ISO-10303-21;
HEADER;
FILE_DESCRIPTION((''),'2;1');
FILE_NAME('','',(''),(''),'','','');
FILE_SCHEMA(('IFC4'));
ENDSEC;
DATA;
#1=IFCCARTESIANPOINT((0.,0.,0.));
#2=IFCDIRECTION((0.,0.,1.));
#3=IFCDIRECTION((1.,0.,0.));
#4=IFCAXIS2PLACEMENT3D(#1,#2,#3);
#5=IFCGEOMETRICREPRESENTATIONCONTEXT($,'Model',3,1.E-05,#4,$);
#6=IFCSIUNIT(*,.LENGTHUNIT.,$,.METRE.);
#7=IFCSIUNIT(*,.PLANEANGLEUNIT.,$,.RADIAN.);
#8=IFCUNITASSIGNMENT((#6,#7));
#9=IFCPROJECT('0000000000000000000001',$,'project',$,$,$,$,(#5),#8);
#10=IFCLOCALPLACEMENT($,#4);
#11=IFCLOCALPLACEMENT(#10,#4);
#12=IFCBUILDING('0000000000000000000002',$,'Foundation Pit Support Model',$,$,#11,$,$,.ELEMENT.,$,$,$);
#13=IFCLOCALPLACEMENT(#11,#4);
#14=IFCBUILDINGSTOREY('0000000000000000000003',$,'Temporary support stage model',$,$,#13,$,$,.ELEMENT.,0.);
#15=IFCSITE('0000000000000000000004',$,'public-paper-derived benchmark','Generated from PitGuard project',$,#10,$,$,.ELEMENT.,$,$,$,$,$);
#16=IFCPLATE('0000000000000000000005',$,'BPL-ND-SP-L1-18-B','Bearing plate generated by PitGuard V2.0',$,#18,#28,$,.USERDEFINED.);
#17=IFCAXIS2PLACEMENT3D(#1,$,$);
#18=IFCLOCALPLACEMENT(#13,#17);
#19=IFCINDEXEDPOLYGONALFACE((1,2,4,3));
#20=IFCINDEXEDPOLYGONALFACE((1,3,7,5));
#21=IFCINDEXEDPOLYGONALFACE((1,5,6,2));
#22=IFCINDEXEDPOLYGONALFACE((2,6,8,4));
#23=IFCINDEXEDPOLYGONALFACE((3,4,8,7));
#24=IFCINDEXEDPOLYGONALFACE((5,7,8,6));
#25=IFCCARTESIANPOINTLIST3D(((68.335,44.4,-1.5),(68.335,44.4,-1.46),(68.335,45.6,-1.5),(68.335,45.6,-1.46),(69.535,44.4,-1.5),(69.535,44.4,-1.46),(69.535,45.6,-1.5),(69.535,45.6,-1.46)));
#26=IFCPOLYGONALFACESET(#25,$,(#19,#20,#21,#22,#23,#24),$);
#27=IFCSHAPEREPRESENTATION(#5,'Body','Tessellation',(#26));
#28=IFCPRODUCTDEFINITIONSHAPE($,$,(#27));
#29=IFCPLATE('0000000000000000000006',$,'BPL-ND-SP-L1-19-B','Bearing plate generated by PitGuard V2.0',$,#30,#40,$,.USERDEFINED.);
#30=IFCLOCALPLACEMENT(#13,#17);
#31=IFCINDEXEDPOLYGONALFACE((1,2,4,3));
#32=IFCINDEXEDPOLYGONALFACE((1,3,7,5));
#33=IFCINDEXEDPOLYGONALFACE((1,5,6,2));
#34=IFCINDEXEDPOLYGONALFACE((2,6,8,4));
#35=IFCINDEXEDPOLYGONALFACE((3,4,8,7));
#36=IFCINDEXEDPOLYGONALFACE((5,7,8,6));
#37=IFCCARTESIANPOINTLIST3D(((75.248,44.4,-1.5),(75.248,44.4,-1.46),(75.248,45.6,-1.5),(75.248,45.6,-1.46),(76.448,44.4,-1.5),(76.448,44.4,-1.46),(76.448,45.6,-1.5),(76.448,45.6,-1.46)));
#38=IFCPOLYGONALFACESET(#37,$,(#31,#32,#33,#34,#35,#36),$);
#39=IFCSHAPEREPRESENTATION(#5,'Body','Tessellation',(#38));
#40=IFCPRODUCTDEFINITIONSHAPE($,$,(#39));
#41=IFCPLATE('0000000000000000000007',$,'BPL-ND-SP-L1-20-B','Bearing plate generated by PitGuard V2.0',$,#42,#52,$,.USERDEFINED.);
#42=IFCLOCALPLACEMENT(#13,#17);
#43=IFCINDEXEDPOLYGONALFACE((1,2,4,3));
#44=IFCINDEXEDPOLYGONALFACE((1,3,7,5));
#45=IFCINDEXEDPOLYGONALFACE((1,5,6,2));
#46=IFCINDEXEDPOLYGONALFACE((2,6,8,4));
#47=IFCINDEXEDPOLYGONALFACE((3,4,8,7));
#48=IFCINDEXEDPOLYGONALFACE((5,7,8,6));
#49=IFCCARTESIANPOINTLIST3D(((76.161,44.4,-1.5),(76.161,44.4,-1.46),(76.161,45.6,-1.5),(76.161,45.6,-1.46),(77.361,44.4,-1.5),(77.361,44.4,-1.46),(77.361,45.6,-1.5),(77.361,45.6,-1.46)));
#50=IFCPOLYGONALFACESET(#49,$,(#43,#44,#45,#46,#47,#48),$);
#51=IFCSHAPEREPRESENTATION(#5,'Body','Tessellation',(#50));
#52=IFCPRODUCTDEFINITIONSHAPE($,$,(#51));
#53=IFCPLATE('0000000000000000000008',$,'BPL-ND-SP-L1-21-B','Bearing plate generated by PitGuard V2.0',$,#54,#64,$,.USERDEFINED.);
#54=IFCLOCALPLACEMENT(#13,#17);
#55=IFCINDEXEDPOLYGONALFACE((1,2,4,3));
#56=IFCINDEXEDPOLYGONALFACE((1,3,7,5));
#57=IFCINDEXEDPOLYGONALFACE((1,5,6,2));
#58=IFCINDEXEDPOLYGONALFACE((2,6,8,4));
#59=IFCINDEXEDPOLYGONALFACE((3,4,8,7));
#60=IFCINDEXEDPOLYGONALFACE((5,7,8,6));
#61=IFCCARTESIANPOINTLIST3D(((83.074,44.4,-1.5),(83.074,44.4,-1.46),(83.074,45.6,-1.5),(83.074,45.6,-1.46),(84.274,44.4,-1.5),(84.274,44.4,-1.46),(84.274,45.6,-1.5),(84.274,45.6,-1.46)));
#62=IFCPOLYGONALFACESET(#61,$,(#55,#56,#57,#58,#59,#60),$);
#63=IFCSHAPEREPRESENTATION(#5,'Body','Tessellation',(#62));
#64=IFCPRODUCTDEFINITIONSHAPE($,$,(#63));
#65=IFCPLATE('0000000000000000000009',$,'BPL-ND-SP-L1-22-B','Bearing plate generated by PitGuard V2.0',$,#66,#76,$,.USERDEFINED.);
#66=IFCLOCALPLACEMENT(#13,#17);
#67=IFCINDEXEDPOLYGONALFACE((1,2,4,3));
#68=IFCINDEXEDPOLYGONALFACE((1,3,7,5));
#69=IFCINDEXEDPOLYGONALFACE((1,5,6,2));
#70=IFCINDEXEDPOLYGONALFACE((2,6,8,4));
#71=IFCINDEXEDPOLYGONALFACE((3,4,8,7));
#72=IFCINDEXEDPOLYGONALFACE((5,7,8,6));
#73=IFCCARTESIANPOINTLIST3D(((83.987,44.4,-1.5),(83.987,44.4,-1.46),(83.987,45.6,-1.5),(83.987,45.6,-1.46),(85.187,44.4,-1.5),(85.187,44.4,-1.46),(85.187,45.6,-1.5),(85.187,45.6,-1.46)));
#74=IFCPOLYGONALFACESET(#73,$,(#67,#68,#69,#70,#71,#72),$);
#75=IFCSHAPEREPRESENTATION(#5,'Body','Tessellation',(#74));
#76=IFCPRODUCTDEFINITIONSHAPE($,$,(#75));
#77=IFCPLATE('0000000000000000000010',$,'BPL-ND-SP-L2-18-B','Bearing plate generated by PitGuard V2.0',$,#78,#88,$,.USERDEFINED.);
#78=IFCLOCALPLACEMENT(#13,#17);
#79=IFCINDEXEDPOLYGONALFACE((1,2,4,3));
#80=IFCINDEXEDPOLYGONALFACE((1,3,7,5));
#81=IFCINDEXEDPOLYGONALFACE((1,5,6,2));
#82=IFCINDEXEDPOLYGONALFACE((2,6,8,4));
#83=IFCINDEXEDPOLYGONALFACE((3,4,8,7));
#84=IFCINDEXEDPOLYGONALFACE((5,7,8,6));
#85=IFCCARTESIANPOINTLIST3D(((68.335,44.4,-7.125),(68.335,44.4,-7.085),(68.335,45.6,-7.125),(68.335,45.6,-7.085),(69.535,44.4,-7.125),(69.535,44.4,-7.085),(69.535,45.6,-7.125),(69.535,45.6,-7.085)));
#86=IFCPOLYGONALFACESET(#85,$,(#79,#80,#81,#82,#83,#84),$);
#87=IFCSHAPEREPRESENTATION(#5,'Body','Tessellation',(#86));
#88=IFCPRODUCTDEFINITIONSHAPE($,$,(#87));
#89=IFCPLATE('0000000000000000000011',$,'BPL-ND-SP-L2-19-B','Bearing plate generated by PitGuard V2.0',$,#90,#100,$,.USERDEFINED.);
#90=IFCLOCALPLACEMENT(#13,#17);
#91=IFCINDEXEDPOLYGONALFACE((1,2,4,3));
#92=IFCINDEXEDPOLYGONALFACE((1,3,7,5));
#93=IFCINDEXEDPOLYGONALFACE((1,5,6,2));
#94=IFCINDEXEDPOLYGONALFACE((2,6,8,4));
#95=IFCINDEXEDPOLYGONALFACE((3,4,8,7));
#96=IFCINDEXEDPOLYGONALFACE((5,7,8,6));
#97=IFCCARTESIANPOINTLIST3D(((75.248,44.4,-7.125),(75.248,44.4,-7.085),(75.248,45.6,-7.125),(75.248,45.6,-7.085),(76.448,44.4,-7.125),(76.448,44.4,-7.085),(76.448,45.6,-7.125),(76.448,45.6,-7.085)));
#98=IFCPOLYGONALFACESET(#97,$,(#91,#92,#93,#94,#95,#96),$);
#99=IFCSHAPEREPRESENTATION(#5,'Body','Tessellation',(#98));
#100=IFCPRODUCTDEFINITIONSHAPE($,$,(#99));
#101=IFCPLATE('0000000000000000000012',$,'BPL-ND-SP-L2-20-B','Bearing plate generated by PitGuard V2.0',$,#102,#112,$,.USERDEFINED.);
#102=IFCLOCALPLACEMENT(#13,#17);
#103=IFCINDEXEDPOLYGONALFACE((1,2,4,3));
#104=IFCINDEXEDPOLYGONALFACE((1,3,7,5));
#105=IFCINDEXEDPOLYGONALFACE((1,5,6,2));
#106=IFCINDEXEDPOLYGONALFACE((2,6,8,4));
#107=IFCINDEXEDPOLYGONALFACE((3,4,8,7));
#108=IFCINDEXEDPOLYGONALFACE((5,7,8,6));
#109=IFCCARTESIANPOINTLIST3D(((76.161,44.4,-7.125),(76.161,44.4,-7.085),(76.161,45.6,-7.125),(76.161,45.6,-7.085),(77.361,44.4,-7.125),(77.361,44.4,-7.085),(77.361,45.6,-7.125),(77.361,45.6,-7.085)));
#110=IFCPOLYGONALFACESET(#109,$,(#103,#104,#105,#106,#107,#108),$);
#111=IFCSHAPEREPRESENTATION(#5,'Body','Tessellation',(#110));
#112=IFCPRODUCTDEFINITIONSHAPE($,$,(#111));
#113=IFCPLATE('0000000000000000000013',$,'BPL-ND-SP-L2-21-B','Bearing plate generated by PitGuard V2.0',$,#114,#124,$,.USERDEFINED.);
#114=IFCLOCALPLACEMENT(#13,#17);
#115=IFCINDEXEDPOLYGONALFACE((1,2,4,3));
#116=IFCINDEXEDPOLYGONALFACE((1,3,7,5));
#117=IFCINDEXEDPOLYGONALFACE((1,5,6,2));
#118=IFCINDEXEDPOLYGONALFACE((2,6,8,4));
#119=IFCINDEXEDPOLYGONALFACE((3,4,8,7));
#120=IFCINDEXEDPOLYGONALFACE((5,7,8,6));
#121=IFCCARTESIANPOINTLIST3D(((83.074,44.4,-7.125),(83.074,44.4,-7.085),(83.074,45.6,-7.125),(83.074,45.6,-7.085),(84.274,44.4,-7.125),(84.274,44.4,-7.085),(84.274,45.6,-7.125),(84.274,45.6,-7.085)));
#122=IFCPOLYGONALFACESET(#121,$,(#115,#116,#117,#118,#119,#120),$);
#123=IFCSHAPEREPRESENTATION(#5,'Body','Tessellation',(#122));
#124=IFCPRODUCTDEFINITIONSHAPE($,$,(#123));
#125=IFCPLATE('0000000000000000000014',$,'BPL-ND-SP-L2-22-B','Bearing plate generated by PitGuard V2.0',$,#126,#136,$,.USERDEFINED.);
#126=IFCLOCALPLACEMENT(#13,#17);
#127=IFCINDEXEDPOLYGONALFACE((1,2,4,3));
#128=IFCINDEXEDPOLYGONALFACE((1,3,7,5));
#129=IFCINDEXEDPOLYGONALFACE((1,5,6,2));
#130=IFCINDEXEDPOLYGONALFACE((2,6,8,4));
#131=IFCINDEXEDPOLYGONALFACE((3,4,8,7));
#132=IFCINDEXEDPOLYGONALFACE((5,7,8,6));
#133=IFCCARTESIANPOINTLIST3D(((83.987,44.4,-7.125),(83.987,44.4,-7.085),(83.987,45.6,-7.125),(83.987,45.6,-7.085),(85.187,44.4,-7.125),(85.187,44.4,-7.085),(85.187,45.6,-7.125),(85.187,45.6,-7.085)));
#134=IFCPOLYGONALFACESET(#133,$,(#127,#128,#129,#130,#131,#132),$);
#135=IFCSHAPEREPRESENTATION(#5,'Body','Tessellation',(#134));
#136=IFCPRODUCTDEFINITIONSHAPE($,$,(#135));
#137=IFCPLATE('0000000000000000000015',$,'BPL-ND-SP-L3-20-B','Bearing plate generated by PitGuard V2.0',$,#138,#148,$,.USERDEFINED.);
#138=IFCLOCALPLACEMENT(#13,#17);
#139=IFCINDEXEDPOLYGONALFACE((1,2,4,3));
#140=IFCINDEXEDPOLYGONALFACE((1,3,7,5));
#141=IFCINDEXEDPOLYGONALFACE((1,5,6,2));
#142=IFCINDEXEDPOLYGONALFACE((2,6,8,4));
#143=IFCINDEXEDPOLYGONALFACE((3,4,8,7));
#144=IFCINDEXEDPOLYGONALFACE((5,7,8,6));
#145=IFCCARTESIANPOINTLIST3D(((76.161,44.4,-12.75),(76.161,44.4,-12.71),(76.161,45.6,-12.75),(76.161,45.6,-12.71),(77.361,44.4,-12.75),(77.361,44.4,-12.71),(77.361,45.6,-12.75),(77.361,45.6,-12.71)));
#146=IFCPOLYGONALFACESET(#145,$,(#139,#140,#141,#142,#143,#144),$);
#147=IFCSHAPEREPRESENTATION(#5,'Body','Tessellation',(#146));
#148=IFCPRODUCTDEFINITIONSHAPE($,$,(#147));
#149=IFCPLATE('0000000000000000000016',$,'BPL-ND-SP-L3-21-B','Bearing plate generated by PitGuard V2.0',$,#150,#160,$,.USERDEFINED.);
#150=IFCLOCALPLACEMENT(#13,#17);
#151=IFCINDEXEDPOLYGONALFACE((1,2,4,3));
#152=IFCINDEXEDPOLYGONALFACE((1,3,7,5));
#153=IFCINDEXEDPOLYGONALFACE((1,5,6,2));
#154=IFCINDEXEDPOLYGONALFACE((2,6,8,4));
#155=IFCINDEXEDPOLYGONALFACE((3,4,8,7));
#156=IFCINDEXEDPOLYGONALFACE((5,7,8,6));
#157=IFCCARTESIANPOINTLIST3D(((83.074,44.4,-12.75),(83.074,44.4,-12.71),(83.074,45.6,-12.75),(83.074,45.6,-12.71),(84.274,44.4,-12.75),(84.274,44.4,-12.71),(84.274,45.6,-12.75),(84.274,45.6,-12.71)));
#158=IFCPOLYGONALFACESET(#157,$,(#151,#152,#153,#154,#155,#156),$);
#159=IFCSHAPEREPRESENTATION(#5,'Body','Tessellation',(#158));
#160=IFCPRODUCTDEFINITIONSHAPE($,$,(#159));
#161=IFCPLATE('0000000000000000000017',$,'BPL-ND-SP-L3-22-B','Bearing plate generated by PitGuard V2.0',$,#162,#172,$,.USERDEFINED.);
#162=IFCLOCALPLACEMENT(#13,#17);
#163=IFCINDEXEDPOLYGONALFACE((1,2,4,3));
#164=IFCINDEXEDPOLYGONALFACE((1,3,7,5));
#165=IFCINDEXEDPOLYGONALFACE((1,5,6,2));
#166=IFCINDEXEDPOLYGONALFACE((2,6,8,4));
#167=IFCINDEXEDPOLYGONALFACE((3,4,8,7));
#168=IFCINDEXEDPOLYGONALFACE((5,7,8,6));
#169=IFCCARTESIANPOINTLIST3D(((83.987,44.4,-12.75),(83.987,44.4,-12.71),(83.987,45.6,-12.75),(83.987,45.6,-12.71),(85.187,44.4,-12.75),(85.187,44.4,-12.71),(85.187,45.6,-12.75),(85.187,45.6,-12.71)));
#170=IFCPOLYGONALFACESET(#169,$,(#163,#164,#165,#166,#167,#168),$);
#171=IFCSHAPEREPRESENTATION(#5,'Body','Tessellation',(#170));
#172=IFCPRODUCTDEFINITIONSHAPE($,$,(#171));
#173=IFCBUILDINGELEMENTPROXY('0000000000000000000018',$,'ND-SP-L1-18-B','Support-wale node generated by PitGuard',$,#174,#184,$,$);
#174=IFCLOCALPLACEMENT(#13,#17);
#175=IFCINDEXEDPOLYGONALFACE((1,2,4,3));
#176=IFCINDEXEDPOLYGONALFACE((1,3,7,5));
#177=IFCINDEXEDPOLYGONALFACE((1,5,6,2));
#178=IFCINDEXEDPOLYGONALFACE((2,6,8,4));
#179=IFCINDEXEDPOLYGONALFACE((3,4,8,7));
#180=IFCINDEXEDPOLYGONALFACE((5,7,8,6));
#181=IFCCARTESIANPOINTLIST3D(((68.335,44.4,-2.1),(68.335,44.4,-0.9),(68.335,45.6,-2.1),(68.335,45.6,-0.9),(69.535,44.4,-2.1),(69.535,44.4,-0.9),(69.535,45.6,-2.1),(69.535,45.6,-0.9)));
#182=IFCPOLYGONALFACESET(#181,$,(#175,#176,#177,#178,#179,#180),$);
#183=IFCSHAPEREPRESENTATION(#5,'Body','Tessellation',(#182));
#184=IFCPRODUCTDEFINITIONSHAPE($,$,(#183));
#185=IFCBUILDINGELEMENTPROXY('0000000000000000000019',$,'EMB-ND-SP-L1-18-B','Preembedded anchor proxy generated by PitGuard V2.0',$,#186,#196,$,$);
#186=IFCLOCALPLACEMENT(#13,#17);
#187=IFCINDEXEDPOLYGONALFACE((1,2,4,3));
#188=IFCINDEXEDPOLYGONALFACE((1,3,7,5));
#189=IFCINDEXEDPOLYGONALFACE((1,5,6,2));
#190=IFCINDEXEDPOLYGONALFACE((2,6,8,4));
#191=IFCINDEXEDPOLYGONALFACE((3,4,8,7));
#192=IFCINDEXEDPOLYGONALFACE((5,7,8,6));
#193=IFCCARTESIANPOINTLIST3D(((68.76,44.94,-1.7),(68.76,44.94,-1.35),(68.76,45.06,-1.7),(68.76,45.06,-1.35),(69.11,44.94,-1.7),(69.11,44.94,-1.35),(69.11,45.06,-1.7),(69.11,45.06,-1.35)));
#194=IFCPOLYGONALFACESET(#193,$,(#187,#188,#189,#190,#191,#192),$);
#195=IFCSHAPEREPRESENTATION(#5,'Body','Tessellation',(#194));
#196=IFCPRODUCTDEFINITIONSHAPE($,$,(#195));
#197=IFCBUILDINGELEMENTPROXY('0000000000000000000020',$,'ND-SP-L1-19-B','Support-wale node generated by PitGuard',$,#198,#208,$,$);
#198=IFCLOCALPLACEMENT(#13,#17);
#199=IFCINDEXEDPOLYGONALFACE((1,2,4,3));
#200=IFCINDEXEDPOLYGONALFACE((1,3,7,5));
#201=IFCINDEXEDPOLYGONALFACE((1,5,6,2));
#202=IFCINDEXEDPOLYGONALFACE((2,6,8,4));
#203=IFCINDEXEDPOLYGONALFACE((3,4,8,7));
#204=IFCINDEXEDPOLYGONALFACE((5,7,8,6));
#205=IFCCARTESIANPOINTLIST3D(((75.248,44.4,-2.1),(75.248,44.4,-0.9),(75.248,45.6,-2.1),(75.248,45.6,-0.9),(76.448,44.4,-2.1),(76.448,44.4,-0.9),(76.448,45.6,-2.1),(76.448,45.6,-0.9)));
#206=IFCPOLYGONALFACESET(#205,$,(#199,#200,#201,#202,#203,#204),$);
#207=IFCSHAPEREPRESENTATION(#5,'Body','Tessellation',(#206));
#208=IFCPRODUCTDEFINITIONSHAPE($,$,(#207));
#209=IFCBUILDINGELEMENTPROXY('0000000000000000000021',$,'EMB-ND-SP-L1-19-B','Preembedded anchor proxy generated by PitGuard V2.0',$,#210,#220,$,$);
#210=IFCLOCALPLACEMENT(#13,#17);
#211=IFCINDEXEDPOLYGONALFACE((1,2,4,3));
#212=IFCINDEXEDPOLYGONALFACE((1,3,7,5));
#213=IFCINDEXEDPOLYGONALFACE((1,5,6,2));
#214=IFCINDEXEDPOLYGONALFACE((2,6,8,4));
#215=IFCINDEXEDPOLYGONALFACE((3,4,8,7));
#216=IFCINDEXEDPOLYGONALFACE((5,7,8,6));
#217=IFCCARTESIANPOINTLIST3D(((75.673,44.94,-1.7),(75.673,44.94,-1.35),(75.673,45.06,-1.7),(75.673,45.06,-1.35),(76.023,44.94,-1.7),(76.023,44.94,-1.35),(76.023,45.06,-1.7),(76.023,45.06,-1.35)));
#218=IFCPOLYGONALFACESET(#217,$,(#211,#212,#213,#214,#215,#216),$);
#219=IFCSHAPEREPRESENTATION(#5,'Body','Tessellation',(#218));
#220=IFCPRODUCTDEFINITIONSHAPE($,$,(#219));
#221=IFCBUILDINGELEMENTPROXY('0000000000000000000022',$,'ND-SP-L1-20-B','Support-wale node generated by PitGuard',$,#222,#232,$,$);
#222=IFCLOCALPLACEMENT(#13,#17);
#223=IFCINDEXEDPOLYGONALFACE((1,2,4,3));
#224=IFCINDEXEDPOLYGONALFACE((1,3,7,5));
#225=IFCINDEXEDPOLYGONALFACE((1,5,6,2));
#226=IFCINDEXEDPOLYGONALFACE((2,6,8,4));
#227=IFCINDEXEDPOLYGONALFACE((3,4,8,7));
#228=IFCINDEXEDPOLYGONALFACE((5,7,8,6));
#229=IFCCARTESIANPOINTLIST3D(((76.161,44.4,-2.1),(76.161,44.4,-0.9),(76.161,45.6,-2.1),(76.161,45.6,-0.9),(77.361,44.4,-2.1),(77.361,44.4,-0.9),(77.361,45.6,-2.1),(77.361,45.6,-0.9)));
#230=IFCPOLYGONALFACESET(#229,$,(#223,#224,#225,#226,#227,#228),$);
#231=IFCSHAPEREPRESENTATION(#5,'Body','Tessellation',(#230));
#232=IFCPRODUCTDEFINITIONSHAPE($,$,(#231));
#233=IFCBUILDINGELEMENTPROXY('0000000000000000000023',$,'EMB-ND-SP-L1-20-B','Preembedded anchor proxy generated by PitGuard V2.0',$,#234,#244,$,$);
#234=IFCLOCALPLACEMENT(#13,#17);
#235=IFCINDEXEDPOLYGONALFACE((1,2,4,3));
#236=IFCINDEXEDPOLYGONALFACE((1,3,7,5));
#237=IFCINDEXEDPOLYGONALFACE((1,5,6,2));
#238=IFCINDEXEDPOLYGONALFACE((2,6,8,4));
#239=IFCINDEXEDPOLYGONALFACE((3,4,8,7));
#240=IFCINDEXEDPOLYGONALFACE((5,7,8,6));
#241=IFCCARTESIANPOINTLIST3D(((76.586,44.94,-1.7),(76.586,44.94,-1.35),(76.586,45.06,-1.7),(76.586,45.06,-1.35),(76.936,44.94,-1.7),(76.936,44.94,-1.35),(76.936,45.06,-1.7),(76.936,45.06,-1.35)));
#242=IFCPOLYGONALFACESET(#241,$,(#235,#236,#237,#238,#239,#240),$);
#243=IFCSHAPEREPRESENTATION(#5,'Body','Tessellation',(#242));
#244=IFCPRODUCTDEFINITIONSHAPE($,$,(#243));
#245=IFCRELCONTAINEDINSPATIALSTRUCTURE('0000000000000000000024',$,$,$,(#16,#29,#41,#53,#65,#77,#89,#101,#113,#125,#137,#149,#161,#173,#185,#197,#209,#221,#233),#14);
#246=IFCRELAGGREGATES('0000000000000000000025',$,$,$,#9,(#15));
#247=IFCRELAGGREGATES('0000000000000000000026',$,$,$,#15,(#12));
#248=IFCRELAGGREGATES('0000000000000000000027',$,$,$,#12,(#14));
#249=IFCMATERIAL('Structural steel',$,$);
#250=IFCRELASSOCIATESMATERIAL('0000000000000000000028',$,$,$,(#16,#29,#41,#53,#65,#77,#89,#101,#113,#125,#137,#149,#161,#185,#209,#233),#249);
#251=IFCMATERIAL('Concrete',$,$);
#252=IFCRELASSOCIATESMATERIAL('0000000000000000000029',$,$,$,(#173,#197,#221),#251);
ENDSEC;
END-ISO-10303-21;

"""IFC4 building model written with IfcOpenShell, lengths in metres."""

from ifc_helpers import new_model, si_unit, frame, origin_with_axes, origin_2d, place, context, project, spatial, rectangle, extrude, material, element, save


model = new_model("IFC4")

# Units and contexts
model_context = context("Model", 3, precision=1e-05, world=origin_with_axes())
ifc_project = project(units=[si_unit("LENGTHUNIT", "METRE"), si_unit("PLANEANGLEUNIT", "RADIAN")], contexts=[model_context])

# Site, building, storey
site_placement = place(None, origin_with_axes())
site = spatial("IfcSite", under=ifc_project, at=site_placement, Name="public-paper-derived benchmark", Description="Generated from PitGuard project", CompositionType="ELEMENT")
building_placement = place(site_placement, origin_with_axes())
building = spatial("IfcBuilding", under=site, at=building_placement, Name="Foundation Pit Support Model", CompositionType="ELEMENT")
storey_placement = place(building_placement, origin_with_axes())
storey = spatial("IfcBuildingStorey", under=building, at=storey_placement, Name="Temporary support stage model", CompositionType="ELEMENT", Elevation=0.0)

# Plates
ifc_material_1 = material(Name="Structural steel")
for number, where, z_axis, x_axis, name in (
    (1, (68.935, 45.0, -1.5), (0.0, 0.0, 1.0), (1.0, 0.0, 0.0), "BPL-ND-SP-L1-18-B"),
    (2, (75.848, 45.0, -1.5), (0.0, 0.0, 1.0), (1.0, 0.0, 0.0), "BPL-ND-SP-L1-19-B"),
    (3, (76.761, 45.0, -1.5), (0.0, 0.0, 1.0), (1.0, 0.0, 0.0), "BPL-ND-SP-L1-20-B"),
    (4, (83.674, 45.0, -1.5), (0.0, 0.0, 1.0), (1.0, 0.0, 0.0), "BPL-ND-SP-L1-21-B"),
    (5, (84.587, 45.0, -1.5), (0.0, 0.0, 1.0), (1.0, 0.0, 0.0), "BPL-ND-SP-L1-22-B"),
    (6, (68.935, 45.0, -7.125), (0.0, 0.0, 1.0), (1.0, 0.0, 0.0), "BPL-ND-SP-L2-18-B"),
    (7, (75.848, 45.0, -7.125), (0.0, 0.0, 1.0), (1.0, 0.0, 0.0), "BPL-ND-SP-L2-19-B"),
    (8, (76.761, 45.0, -7.125), (0.0, 0.0, 1.0), (1.0, 0.0, 0.0), "BPL-ND-SP-L2-20-B"),
    (9, (83.674, 45.0, -7.125), (0.0, 0.0, 1.0), (1.0, 0.0, 0.0), "BPL-ND-SP-L2-21-B"),
    (10, (84.587, 45.0, -7.125), (0.0, 0.0, 1.0), (1.0, 0.0, 0.0), "BPL-ND-SP-L2-22-B"),
    (11, (76.761, 45.0, -12.75), (0.0, 0.0, 1.0), (1.0, 0.0, 0.0), "BPL-ND-SP-L3-20-B"),
    (12, (83.674, 45.0, -12.75), (0.0, 0.0, 1.0), (1.0, 0.0, 0.0), "BPL-ND-SP-L3-21-B"),
    (13, (84.587, 45.0, -12.75), (0.0, 0.0, 1.0), (1.0, 0.0, 0.0), "BPL-ND-SP-L3-22-B"),
):
    element("IfcPlate", number, at=place(storey_placement, frame(where, z_axis=z_axis, x_axis=x_axis)), inside=storey, material=ifc_material_1, Name=name, Description="Bearing plate generated by PitGuard V2.0", PredefinedType="USERDEFINED", context=model_context, shape_type="SweptSolid", body=[
        extrude(rectangle(XDim=1.2, YDim=1.2, at=origin_2d()), origin_with_axes(), (0.0, 0.0, 1.0), 0.04),
    ])

# Building element proxies
ifc_material_2 = material(Name="Concrete")
proxy_1_placement = place(storey_placement, frame((68.935, 45.0, -2.1), z_axis=(0.0, 0.0, 1.0), x_axis=(1.0, 0.0, 0.0)))
element("IfcBuildingElementProxy", 14, at=proxy_1_placement, inside=storey, material=ifc_material_2, Name="ND-SP-L1-18-B", Description="Support-wale node generated by PitGuard", context=model_context, shape_type="SweptSolid", body=[
    extrude(rectangle(XDim=1.2, YDim=1.2, at=origin_2d()), origin_with_axes(), (0.0, 0.0, 1.0), 1.2),
])
proxy_2_placement = place(storey_placement, frame((68.935, 45.0, -1.7), z_axis=(0.0, 0.0, 1.0), x_axis=(1.0, 0.0, 0.0)))
element("IfcBuildingElementProxy", 15, at=proxy_2_placement, inside=storey, material=ifc_material_1, Name="EMB-ND-SP-L1-18-B", Description="Preembedded anchor proxy generated by PitGuard V2.0", context=model_context, shape_type="SweptSolid", body=[
    extrude(rectangle(XDim=0.35, YDim=0.12, at=origin_2d()), origin_with_axes(), (0.0, 0.0, 1.0), 0.35),
])
proxy_3_placement = place(storey_placement, frame((75.848, 45.0, -2.1), z_axis=(0.0, 0.0, 1.0), x_axis=(1.0, 0.0, 0.0)))
element("IfcBuildingElementProxy", 16, at=proxy_3_placement, inside=storey, material=ifc_material_2, Name="ND-SP-L1-19-B", Description="Support-wale node generated by PitGuard", context=model_context, shape_type="SweptSolid", body=[
    extrude(rectangle(XDim=1.2, YDim=1.2, at=origin_2d()), origin_with_axes(), (0.0, 0.0, 1.0), 1.2),
])
proxy_4_placement = place(storey_placement, frame((75.848, 45.0, -1.7), z_axis=(0.0, 0.0, 1.0), x_axis=(1.0, 0.0, 0.0)))
element("IfcBuildingElementProxy", 17, at=proxy_4_placement, inside=storey, material=ifc_material_1, Name="EMB-ND-SP-L1-19-B", Description="Preembedded anchor proxy generated by PitGuard V2.0", context=model_context, shape_type="SweptSolid", body=[
    extrude(rectangle(XDim=0.35, YDim=0.12, at=origin_2d()), origin_with_axes(), (0.0, 0.0, 1.0), 0.35),
])
proxy_5_placement = place(storey_placement, frame((76.761, 45.0, -2.1), z_axis=(0.0, 0.0, 1.0), x_axis=(1.0, 0.0, 0.0)))
element("IfcBuildingElementProxy", 18, at=proxy_5_placement, inside=storey, material=ifc_material_2, Name="ND-SP-L1-20-B", Description="Support-wale node generated by PitGuard", context=model_context, shape_type="SweptSolid", body=[
    extrude(rectangle(XDim=1.2, YDim=1.2, at=origin_2d()), origin_with_axes(), (0.0, 0.0, 1.0), 1.2),
])
proxy_6_placement = place(storey_placement, frame((76.761, 45.0, -1.7), z_axis=(0.0, 0.0, 1.0), x_axis=(1.0, 0.0, 0.0)))
element("IfcBuildingElementProxy", 19, at=proxy_6_placement, inside=storey, material=ifc_material_1, Name="EMB-ND-SP-L1-20-B", Description="Preembedded anchor proxy generated by PitGuard V2.0", context=model_context, shape_type="SweptSolid", body=[
    extrude(rectangle(XDim=0.35, YDim=0.12, at=origin_2d()), origin_with_axes(), (0.0, 0.0, 1.0), 0.35),
])

save(model, "model.ifc")
